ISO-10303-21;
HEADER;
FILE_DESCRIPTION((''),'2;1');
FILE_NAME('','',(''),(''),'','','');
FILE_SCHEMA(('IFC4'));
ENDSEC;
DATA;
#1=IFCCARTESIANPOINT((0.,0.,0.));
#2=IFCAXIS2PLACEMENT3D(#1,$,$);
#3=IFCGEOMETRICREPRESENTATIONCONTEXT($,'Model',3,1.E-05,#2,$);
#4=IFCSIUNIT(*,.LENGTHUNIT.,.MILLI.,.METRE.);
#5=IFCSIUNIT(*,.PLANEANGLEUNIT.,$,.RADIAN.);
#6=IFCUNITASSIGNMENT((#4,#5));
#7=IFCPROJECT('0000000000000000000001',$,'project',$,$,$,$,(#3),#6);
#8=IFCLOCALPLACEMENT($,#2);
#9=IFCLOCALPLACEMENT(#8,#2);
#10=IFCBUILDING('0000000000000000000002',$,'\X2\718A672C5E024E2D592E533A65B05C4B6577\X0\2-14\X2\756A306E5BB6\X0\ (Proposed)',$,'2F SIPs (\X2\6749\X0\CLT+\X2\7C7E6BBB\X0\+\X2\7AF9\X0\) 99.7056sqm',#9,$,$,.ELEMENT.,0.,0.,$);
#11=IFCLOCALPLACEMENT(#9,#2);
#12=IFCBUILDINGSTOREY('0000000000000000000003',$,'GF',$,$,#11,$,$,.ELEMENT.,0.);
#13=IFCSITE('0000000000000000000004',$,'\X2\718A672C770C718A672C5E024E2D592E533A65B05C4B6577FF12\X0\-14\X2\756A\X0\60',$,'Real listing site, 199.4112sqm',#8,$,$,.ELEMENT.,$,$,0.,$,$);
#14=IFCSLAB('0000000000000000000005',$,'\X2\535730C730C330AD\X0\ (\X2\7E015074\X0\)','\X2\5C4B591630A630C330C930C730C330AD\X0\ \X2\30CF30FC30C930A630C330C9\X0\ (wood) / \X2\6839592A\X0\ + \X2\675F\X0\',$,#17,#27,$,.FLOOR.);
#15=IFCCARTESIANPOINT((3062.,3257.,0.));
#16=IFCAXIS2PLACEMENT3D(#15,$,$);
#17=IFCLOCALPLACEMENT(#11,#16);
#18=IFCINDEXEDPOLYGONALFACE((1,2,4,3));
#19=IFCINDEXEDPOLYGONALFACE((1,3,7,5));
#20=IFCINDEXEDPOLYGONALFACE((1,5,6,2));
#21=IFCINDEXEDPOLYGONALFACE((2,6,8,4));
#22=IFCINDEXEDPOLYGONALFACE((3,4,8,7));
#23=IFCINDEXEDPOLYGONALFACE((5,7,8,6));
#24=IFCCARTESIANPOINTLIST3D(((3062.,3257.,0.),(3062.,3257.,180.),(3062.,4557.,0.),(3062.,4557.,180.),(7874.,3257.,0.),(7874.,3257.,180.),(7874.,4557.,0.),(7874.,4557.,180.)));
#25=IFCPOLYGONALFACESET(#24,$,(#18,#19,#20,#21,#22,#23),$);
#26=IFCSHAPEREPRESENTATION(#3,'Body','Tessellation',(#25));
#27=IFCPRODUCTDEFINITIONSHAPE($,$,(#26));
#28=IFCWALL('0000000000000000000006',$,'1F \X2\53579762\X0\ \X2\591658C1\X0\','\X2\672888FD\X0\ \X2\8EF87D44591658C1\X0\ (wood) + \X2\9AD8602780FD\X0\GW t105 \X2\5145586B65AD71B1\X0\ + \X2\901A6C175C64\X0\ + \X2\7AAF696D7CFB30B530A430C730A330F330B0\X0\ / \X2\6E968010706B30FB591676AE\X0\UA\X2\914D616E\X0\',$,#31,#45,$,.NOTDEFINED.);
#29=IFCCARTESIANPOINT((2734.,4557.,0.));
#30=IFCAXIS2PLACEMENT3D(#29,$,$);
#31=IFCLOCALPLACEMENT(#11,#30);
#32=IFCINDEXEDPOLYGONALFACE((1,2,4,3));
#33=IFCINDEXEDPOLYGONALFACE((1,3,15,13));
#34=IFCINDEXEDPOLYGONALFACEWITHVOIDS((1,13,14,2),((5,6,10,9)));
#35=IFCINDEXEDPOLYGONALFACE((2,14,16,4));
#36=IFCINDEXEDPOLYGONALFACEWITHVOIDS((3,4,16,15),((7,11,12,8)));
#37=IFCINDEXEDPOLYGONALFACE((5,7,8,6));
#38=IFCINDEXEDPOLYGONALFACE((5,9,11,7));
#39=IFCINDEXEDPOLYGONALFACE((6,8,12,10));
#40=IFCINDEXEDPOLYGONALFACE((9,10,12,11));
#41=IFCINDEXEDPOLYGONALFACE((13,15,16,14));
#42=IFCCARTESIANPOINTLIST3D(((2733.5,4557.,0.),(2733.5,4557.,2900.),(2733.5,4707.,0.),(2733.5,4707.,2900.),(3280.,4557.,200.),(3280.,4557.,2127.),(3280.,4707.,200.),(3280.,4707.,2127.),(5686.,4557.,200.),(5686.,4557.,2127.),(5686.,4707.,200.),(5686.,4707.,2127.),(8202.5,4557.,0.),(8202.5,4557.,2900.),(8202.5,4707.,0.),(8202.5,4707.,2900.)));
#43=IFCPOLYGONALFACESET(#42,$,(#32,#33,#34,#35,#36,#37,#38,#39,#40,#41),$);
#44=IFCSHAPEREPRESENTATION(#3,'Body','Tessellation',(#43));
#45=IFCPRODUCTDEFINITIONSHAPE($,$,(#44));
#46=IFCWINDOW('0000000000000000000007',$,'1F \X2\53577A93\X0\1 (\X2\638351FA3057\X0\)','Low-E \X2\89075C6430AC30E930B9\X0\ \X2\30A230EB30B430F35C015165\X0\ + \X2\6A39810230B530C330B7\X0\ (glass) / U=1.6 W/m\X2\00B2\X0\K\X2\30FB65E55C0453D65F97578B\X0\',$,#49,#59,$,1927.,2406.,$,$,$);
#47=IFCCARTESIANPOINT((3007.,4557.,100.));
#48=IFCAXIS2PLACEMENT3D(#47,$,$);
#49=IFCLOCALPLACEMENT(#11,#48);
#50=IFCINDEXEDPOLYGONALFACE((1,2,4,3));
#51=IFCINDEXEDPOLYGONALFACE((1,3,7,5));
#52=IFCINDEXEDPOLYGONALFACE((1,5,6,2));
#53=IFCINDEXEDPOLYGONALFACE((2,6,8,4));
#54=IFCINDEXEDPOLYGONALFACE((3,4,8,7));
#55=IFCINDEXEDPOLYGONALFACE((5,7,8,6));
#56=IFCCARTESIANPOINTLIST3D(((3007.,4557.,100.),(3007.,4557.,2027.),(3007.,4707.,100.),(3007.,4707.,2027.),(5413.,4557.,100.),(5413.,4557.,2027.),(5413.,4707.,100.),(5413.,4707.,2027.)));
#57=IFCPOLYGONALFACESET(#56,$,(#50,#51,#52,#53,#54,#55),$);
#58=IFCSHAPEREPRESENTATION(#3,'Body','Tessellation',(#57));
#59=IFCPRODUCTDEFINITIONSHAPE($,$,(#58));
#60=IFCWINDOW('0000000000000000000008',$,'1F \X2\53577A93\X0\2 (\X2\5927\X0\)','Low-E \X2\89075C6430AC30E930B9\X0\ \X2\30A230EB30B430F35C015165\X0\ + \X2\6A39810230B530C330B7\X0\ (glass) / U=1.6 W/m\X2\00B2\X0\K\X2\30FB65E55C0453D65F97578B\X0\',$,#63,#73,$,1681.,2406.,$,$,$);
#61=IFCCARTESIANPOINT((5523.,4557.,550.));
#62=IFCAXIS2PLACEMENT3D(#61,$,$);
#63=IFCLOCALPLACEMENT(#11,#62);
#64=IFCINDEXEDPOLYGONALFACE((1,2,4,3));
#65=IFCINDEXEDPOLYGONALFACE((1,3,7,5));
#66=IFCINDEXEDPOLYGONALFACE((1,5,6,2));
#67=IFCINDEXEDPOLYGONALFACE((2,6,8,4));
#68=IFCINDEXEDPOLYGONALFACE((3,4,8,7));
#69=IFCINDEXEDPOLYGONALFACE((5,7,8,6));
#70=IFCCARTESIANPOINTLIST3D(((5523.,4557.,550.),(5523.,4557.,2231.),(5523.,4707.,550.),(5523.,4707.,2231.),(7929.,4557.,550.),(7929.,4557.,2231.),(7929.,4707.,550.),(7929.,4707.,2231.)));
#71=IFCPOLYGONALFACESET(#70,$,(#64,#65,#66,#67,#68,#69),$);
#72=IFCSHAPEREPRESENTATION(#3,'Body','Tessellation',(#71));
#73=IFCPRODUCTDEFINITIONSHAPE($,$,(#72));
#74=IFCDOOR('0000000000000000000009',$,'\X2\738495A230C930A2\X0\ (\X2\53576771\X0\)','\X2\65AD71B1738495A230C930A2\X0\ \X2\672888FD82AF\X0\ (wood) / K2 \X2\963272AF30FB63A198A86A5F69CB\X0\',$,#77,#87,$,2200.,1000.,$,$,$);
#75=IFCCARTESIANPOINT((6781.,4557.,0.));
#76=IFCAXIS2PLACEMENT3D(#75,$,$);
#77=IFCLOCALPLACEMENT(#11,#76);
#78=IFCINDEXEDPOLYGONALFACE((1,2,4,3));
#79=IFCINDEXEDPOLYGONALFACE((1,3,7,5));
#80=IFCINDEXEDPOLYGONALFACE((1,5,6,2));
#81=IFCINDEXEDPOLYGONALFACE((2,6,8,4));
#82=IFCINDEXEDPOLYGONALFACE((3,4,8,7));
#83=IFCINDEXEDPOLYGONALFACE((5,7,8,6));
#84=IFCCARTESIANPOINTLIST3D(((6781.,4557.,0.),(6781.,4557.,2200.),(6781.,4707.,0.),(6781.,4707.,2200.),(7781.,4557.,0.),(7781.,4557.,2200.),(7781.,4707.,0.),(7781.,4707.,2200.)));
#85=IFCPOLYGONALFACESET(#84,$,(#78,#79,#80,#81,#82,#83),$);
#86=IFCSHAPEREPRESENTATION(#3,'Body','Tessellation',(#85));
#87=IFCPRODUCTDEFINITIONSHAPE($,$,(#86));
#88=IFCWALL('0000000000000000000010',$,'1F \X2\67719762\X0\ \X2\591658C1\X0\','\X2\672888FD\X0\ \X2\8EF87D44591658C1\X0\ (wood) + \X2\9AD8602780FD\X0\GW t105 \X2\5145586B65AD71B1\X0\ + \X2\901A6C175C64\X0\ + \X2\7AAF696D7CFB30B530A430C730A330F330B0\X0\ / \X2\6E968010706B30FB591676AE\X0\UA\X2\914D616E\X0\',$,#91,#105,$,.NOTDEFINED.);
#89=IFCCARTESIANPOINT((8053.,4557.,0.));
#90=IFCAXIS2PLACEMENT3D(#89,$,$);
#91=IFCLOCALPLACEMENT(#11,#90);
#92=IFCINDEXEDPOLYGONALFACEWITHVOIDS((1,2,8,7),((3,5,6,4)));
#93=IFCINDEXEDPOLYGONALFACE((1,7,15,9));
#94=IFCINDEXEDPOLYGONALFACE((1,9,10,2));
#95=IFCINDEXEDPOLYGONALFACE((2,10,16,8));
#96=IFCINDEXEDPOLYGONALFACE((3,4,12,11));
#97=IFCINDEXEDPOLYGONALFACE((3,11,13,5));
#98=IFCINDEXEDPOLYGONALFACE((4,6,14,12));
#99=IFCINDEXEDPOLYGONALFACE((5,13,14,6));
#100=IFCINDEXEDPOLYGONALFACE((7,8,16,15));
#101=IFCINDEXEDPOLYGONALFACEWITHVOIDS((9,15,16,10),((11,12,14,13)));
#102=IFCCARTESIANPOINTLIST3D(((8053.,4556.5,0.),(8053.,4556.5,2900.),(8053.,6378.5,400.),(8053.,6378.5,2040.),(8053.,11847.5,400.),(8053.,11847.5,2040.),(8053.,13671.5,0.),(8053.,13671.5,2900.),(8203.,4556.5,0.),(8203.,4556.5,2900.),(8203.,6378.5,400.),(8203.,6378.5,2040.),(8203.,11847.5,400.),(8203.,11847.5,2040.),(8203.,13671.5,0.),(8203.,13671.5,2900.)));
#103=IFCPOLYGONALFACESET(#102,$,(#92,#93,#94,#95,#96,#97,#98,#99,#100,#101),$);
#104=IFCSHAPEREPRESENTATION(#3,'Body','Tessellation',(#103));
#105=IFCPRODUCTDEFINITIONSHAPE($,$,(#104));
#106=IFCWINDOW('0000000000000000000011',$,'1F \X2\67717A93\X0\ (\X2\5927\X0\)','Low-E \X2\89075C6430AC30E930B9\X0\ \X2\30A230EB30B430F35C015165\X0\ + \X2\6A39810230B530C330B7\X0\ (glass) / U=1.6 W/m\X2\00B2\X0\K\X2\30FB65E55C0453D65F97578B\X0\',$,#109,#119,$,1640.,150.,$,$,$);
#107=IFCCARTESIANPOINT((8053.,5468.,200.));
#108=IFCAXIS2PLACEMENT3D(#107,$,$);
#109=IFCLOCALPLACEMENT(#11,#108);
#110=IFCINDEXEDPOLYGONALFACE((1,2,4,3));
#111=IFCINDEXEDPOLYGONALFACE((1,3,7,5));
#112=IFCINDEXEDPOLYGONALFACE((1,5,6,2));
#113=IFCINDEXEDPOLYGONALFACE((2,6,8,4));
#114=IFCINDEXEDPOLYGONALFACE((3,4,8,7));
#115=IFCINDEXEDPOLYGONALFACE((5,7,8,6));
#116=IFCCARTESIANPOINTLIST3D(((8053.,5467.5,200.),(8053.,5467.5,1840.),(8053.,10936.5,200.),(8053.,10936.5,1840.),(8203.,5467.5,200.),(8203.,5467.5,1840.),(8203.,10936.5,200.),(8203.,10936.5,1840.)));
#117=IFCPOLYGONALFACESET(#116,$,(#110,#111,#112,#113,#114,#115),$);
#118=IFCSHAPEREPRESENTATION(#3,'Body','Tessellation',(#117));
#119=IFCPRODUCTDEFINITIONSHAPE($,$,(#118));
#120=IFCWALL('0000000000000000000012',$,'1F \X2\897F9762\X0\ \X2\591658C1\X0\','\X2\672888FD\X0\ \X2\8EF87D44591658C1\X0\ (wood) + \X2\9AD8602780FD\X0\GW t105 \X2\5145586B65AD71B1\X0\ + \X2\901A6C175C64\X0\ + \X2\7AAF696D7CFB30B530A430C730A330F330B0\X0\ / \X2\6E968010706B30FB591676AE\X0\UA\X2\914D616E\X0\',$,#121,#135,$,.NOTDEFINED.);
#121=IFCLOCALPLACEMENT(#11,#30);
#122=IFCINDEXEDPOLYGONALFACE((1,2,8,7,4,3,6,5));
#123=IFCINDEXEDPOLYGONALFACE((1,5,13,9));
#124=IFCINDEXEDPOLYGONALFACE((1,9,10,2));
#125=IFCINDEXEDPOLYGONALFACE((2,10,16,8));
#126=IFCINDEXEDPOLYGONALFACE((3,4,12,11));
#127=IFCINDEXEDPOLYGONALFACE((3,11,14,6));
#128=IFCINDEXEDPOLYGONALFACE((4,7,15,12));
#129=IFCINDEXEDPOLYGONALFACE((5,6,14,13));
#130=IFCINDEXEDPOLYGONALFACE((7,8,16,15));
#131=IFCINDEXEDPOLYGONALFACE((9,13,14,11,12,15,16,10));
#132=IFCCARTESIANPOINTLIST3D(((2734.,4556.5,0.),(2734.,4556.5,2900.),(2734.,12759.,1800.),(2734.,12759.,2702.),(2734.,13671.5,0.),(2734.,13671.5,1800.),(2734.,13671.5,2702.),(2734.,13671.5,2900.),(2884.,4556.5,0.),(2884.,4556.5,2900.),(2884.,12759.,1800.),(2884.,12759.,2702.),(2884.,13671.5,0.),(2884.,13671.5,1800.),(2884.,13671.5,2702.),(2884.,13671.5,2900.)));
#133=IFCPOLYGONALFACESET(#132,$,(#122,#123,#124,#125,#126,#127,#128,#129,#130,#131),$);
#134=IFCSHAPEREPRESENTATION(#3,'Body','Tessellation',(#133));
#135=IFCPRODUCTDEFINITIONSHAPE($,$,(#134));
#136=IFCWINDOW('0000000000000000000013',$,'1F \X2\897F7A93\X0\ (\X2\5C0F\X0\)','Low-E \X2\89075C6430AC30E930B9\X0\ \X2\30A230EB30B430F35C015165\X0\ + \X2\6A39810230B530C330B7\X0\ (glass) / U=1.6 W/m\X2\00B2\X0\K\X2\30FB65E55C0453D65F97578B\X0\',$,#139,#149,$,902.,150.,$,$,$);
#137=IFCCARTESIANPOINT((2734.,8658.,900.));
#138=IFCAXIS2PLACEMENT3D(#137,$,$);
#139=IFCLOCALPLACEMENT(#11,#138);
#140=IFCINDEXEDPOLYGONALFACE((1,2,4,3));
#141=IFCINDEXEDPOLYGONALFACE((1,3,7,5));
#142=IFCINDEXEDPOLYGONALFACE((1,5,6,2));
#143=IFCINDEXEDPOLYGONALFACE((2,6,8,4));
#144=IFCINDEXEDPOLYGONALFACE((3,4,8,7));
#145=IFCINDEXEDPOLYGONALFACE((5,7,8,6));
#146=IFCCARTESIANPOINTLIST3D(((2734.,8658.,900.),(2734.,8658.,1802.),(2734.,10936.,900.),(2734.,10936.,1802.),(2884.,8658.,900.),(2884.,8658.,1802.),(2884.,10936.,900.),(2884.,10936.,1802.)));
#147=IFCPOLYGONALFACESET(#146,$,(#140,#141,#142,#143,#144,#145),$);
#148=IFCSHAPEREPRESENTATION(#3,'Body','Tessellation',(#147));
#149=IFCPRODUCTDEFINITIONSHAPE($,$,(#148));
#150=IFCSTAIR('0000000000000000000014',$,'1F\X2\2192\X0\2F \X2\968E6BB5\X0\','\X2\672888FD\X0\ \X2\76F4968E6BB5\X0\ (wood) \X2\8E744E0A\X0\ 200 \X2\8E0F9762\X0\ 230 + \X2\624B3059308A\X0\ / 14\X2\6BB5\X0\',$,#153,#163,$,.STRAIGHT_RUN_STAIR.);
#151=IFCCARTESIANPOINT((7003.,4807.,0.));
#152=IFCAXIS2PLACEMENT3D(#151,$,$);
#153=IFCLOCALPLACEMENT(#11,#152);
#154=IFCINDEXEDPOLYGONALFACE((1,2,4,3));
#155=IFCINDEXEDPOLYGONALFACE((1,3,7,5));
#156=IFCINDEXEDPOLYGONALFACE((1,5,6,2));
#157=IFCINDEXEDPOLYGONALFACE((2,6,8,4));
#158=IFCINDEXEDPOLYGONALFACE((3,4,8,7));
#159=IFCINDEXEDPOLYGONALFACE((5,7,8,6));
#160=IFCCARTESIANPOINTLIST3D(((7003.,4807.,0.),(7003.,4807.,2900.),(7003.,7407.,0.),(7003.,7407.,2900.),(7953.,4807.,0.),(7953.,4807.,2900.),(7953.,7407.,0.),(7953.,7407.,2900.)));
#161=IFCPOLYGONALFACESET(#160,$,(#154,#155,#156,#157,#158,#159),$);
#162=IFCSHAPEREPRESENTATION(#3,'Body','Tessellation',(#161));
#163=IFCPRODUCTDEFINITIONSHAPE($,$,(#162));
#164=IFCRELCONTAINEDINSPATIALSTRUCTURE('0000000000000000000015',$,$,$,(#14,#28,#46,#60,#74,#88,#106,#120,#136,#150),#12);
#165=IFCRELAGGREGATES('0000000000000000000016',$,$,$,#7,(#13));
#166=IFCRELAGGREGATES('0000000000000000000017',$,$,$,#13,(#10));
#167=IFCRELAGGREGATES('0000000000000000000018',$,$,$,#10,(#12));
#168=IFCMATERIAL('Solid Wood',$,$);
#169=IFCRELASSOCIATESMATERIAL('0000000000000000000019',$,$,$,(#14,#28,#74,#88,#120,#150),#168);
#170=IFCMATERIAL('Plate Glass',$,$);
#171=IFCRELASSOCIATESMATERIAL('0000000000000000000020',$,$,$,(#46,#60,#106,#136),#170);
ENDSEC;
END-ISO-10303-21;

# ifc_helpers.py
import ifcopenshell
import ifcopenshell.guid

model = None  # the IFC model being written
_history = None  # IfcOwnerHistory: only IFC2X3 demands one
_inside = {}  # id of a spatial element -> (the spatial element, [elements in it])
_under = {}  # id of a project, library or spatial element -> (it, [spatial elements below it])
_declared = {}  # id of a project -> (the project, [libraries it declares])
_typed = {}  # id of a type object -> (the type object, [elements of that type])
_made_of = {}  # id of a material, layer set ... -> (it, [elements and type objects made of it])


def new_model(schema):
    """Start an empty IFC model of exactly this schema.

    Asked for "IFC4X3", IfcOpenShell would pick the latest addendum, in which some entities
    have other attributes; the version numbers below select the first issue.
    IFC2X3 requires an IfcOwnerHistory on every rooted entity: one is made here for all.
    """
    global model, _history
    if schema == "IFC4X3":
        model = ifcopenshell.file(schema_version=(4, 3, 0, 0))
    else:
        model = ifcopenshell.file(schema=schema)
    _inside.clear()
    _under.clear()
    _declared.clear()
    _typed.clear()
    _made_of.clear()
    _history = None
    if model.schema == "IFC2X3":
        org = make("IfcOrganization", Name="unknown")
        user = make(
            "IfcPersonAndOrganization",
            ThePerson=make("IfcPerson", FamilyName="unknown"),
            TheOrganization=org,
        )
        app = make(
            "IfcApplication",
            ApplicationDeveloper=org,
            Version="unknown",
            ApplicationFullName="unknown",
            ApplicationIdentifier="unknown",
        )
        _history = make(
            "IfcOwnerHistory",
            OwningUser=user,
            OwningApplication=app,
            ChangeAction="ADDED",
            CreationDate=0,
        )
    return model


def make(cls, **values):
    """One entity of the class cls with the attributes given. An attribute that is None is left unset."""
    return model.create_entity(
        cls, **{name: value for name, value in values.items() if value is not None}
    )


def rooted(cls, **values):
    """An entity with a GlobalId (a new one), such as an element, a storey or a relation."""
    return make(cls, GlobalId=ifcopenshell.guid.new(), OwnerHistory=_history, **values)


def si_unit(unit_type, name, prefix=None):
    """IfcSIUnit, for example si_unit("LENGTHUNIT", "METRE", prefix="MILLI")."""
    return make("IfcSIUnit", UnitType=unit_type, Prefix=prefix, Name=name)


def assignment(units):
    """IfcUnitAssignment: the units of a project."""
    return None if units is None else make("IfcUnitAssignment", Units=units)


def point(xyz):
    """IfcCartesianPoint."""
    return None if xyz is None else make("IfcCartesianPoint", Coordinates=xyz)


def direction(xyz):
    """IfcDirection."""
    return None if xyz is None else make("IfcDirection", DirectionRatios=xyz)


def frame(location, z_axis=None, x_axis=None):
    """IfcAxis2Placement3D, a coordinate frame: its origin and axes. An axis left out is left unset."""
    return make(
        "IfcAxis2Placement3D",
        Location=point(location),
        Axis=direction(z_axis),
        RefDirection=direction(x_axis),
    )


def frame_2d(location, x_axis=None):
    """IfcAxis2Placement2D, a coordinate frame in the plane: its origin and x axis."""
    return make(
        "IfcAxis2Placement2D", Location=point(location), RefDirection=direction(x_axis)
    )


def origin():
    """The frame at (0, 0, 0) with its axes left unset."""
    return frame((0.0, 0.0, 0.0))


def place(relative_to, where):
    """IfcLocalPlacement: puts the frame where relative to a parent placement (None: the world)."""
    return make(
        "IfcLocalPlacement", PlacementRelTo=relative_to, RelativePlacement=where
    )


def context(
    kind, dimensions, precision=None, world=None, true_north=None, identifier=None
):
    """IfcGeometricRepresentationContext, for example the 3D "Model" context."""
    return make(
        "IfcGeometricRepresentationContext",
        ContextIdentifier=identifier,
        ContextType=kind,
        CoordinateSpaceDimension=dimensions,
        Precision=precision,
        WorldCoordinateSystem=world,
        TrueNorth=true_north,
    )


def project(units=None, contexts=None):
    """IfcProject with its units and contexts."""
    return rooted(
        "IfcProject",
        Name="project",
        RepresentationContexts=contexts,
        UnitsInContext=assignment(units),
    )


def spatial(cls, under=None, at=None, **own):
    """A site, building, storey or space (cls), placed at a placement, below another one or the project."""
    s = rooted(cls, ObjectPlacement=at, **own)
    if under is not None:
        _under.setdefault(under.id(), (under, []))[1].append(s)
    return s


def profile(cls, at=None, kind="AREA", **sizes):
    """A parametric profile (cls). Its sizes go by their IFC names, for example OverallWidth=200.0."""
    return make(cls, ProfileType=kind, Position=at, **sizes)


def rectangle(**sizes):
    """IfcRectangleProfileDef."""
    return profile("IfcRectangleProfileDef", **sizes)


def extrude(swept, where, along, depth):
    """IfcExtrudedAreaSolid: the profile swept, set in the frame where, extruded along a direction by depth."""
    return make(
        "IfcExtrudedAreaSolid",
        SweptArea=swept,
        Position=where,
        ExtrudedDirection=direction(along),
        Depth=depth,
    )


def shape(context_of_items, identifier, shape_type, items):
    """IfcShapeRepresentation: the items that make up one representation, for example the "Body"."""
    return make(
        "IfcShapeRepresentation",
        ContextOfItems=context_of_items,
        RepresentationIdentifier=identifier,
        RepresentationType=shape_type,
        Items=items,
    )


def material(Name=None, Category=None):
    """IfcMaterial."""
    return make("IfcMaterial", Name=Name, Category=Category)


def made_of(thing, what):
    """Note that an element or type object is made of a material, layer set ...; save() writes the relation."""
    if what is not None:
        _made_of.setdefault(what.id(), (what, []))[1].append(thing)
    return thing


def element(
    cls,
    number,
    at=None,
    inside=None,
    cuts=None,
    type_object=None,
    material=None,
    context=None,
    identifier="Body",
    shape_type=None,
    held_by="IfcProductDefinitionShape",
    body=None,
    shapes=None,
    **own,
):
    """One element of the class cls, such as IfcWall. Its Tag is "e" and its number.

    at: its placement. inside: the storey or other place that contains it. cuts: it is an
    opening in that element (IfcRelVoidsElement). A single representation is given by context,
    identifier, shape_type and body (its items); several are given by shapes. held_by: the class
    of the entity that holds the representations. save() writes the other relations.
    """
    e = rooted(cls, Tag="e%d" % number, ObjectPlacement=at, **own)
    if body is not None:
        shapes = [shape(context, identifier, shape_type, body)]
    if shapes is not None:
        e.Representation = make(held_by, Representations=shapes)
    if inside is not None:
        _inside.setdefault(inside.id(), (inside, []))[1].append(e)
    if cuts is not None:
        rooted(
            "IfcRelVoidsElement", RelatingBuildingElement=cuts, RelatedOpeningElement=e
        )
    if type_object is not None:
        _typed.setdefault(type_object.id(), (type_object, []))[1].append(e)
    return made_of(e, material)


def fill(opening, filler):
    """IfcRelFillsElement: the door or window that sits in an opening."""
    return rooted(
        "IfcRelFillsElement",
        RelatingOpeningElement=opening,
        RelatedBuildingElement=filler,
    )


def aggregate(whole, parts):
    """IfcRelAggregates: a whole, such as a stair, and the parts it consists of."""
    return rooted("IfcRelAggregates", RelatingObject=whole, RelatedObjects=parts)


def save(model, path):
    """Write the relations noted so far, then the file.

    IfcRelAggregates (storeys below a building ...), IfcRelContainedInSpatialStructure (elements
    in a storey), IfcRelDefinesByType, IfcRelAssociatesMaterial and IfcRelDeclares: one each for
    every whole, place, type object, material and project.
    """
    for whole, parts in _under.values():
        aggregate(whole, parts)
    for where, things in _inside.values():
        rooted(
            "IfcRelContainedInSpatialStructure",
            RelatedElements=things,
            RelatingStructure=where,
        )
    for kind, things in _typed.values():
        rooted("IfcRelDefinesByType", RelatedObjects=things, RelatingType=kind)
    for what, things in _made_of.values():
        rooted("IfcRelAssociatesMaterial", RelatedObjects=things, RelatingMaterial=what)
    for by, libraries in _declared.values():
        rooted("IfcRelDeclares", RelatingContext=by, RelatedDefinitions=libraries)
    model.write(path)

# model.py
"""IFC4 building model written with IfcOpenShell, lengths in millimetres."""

from ifc_helpers import new_model, si_unit, frame, frame_2d, origin, place, context, project, spatial, rectangle, extrude, material, element, fill, save


model = new_model("IFC4")

# Units and contexts
model_context = context("Model", 3, precision=1e-05, world=origin())
ifc_project = project(units=[si_unit("LENGTHUNIT", "METRE", prefix="MILLI"), si_unit("PLANEANGLEUNIT", "RADIAN")], contexts=[model_context])

# Site, building, storey
site_placement = place(None, origin())
site = spatial("IfcSite", under=ifc_project, at=site_placement, Name="熊本県熊本市中央区新屋敷２-14番60", ObjectType="Real listing site, 199.4112sqm", CompositionType="ELEMENT", RefElevation=0.0)
building_placement = place(site_placement, origin())
building = spatial("IfcBuilding", under=site, at=building_placement, Name="熊本市中央区新屋敷2-14番の家 (Proposed)", ObjectType="2F SIPs (杉CLT+籾殻+竹) 99.7056sqm", CompositionType="ELEMENT", ElevationOfRefHeight=0.0, ElevationOfTerrain=0.0)
storey_placement = place(building_placement, origin())
storey = spatial("IfcBuildingStorey", under=building, at=storey_placement, Name="GF", CompositionType="ELEMENT", Elevation=0.0)

# Slab
ifc_material_1 = material(Name="Solid Wood")
slab_1_placement = place(storey_placement, frame((3062.0, 3257.0, 0.0)))
element("IfcSlab", 1, at=slab_1_placement, inside=storey, material=ifc_material_1, Name="南デッキ (縁側)", Description="屋外ウッドデッキ ハードウッド (wood) / 根太 + 束", PredefinedType="FLOOR", context=model_context, shape_type="SweptSolid", body=[
    extrude(rectangle(XDim=4812.0, YDim=1300.0, at=frame_2d((2406.0, 650.0))), frame((3062.0, 3257.0, 0.0)), (0.0, 0.0, 1.0), 180.0),
])

# Wall, openings, windows, door
wall_1_placement = place(storey_placement, frame((2734.0, 4557.0, 0.0)))
wall_1 = element("IfcWall", 2, at=wall_1_placement, inside=storey, material=ifc_material_1, Name="1F 南面 外壁", Description="木製 軸組外壁 (wood) + 高性能GW t105 充填断熱 + 通気層 + 窯業系サイディング / 準耐火・外皮UA配慮", PredefinedType="NOTDEFINED", context=model_context, shape_type="SweptSolid", body=[
    extrude(rectangle(XDim=5469.0, YDim=150.0, at=frame_2d((2734.0, 75.0))), frame((2734.0, 4557.0, 0.0)), (0.0, 0.0, 1.0), 2900.0),
])
opening_1_placement = place(storey_placement, frame((3007.0, 4557.0, 100.0)))
opening_1 = element("IfcOpeningElement", 3, at=opening_1_placement, cuts=wall_1, PredefinedType="NOTDEFINED", context=model_context, shape_type="SweptSolid", body=[
    extrude(rectangle(XDim=2406.0, YDim=150.0, at=frame_2d((1203.0, 75.0))), frame((3007.0, 4557.0, 100.0)), (0.0, 0.0, 1.0), 1927.0),
])
opening_2_placement = place(storey_placement, frame((5523.0, 4557.0, 550.0)))
opening_2 = element("IfcOpeningElement", 4, at=opening_2_placement, cuts=wall_1, PredefinedType="NOTDEFINED", context=model_context, shape_type="SweptSolid", body=[
    extrude(rectangle(XDim=2406.0, YDim=150.0, at=frame_2d((1203.0, 75.0))), frame((5523.0, 4557.0, 550.0)), (0.0, 0.0, 1.0), 1681.0),
])
opening_3_placement = place(storey_placement, frame((6781.0, 4557.0, 0.0)))
opening_3 = element("IfcOpeningElement", 5, at=opening_3_placement, cuts=wall_1, PredefinedType="NOTDEFINED", context=model_context, shape_type="SweptSolid", body=[
    extrude(rectangle(XDim=1000.0, YDim=150.0, at=frame_2d((500.0, 75.0))), frame((6781.0, 4557.0, 0.0)), (0.0, 0.0, 1.0), 2200.0),
])
ifc_material_2 = material(Name="Plate Glass")
window_1_placement = place(storey_placement, frame((3007.0, 4557.0, 100.0)))
window_1 = element("IfcWindow", 6, at=window_1_placement, inside=storey, material=ifc_material_2, Name="1F 南窓1 (掃出し)", Description="Low-E 複層ガラス アルゴン封入 + 樹脂サッシ (glass) / U=1.6 W/m²K・日射取得型", OverallHeight=1927.0, OverallWidth=2406.0, context=model_context, shape_type="SweptSolid", body=[
    extrude(rectangle(XDim=2406.0, YDim=150.0, at=frame_2d((1203.0, 75.0))), frame((3007.0, 4557.0, 100.0)), (0.0, 0.0, 1.0), 1927.0),
])
fill(opening_1, window_1)
window_2_placement = place(storey_placement, frame((5523.0, 4557.0, 550.0)))
window_2 = element("IfcWindow", 7, at=window_2_placement, inside=storey, material=ifc_material_2, Name="1F 南窓2 (大)", Description="Low-E 複層ガラス アルゴン封入 + 樹脂サッシ (glass) / U=1.6 W/m²K・日射取得型", OverallHeight=1681.0, OverallWidth=2406.0, context=model_context, shape_type="SweptSolid", body=[
    extrude(rectangle(XDim=2406.0, YDim=150.0, at=frame_2d((1203.0, 75.0))), frame((5523.0, 4557.0, 550.0)), (0.0, 0.0, 1.0), 1681.0),
])
fill(opening_2, window_2)
door_placement = place(storey_placement, frame((6781.0, 4557.0, 0.0)))
door = element("IfcDoor", 8, at=door_placement, inside=storey, material=ifc_material_1, Name="玄関ドア (南東)", Description="断熱玄関ドア 木製芯 (wood) / K2 防犯・採風機構", OverallHeight=2200.0, OverallWidth=1000.0, context=model_context, shape_type="SweptSolid", body=[
    extrude(rectangle(XDim=1000.0, YDim=150.0, at=frame_2d((500.0, 75.0))), frame((6781.0, 4557.0, 0.0)), (0.0, 0.0, 1.0), 2200.0),
])
fill(opening_3, door)

# Walls, openings, windows
wall_2_placement = place(storey_placement, frame((8053.0, 4557.0, 0.0)))
wall_2 = element("IfcWall", 9, at=wall_2_placement, inside=storey, material=ifc_material_1, Name="1F 東面 外壁", Description="木製 軸組外壁 (wood) + 高性能GW t105 充填断熱 + 通気層 + 窯業系サイディング / 準耐火・外皮UA配慮", PredefinedType="NOTDEFINED", context=model_context, shape_type="SweptSolid", body=[
    extrude(rectangle(XDim=150.0, YDim=9115.0, at=frame_2d((75.0, 4557.0))), frame((8053.0, 4557.0, 0.0)), (0.0, 0.0, 1.0), 2900.0),
])
opening_4_placement = place(storey_placement, frame((8053.0, 5468.0, 200.0)))
opening_4 = element("IfcOpeningElement", 10, at=opening_4_placement, cuts=wall_2, PredefinedType="NOTDEFINED", context=model_context, shape_type="SweptSolid", body=[
    extrude(rectangle(XDim=150.0, YDim=5469.0, at=frame_2d((75.0, 2734.0))), frame((8053.0, 5468.0, 200.0)), (0.0, 0.0, 1.0), 1640.0),
])
window_3_placement = place(storey_placement, frame((8053.0, 5468.0, 200.0)))
window_3 = element("IfcWindow", 11, at=window_3_placement, inside=storey, material=ifc_material_2, Name="1F 東窓 (大)", Description="Low-E 複層ガラス アルゴン封入 + 樹脂サッシ (glass) / U=1.6 W/m²K・日射取得型", OverallHeight=1640.0, OverallWidth=150.0, context=model_context, shape_type="SweptSolid", body=[
    extrude(rectangle(XDim=150.0, YDim=5469.0, at=frame_2d((75.0, 2734.0))), frame((8053.0, 5468.0, 200.0)), (0.0, 0.0, 1.0), 1640.0),
])
fill(opening_4, window_3)
wall_3_placement = place(storey_placement, frame((2734.0, 4557.0, 0.0)))
wall_3 = element("IfcWall", 12, at=wall_3_placement, inside=storey, material=ifc_material_1, Name="1F 西面 外壁", Description="木製 軸組外壁 (wood) + 高性能GW t105 充填断熱 + 通気層 + 窯業系サイディング / 準耐火・外皮UA配慮", PredefinedType="NOTDEFINED", context=model_context, shape_type="SweptSolid", body=[
    extrude(rectangle(XDim=150.0, YDim=9115.0, at=frame_2d((75.0, 4557.0))), frame((2734.0, 4557.0, 0.0)), (0.0, 0.0, 1.0), 2900.0),
])
opening_5_placement = place(storey_placement, frame((2734.0, 8658.0, 900.0)))
opening_5 = element("IfcOpeningElement", 13, at=opening_5_placement, cuts=wall_3, PredefinedType="NOTDEFINED", context=model_context, shape_type="SweptSolid", body=[
    extrude(rectangle(XDim=150.0, YDim=2278.0, at=frame_2d((75.0, 1139.0))), frame((2734.0, 8658.0, 900.0)), (0.0, 0.0, 1.0), 902.0),
])
window_4_placement = place(storey_placement, frame((2734.0, 8658.0, 900.0)))
window_4 = element("IfcWindow", 14, at=window_4_placement, inside=storey, material=ifc_material_2, Name="1F 西窓 (小)", Description="Low-E 複層ガラス アルゴン封入 + 樹脂サッシ (glass) / U=1.6 W/m²K・日射取得型", OverallHeight=902.0, OverallWidth=150.0, context=model_context, shape_type="SweptSolid", body=[
    extrude(rectangle(XDim=150.0, YDim=2278.0, at=frame_2d((75.0, 1139.0))), frame((2734.0, 8658.0, 900.0)), (0.0, 0.0, 1.0), 902.0),
])
fill(opening_5, window_4)

# Stair
stair_placement = place(storey_placement, frame((7003.0, 4807.0, 0.0)))
element("IfcStair", 15, at=stair_placement, inside=storey, material=ifc_material_1, Name="1F→2F 階段", Description="木製 直階段 (wood) 蹴上 200 踏面 230 + 手すり / 14段", PredefinedType="STRAIGHT_RUN_STAIR", context=model_context, shape_type="SweptSolid", body=[
    extrude(rectangle(XDim=950.0, YDim=2600.0, at=frame_2d((475.0, 1300.0))), frame((7003.0, 4807.0, 0.0)), (0.0, 0.0, 1.0), 2900.0),
])

save(model, "model.ifc")
